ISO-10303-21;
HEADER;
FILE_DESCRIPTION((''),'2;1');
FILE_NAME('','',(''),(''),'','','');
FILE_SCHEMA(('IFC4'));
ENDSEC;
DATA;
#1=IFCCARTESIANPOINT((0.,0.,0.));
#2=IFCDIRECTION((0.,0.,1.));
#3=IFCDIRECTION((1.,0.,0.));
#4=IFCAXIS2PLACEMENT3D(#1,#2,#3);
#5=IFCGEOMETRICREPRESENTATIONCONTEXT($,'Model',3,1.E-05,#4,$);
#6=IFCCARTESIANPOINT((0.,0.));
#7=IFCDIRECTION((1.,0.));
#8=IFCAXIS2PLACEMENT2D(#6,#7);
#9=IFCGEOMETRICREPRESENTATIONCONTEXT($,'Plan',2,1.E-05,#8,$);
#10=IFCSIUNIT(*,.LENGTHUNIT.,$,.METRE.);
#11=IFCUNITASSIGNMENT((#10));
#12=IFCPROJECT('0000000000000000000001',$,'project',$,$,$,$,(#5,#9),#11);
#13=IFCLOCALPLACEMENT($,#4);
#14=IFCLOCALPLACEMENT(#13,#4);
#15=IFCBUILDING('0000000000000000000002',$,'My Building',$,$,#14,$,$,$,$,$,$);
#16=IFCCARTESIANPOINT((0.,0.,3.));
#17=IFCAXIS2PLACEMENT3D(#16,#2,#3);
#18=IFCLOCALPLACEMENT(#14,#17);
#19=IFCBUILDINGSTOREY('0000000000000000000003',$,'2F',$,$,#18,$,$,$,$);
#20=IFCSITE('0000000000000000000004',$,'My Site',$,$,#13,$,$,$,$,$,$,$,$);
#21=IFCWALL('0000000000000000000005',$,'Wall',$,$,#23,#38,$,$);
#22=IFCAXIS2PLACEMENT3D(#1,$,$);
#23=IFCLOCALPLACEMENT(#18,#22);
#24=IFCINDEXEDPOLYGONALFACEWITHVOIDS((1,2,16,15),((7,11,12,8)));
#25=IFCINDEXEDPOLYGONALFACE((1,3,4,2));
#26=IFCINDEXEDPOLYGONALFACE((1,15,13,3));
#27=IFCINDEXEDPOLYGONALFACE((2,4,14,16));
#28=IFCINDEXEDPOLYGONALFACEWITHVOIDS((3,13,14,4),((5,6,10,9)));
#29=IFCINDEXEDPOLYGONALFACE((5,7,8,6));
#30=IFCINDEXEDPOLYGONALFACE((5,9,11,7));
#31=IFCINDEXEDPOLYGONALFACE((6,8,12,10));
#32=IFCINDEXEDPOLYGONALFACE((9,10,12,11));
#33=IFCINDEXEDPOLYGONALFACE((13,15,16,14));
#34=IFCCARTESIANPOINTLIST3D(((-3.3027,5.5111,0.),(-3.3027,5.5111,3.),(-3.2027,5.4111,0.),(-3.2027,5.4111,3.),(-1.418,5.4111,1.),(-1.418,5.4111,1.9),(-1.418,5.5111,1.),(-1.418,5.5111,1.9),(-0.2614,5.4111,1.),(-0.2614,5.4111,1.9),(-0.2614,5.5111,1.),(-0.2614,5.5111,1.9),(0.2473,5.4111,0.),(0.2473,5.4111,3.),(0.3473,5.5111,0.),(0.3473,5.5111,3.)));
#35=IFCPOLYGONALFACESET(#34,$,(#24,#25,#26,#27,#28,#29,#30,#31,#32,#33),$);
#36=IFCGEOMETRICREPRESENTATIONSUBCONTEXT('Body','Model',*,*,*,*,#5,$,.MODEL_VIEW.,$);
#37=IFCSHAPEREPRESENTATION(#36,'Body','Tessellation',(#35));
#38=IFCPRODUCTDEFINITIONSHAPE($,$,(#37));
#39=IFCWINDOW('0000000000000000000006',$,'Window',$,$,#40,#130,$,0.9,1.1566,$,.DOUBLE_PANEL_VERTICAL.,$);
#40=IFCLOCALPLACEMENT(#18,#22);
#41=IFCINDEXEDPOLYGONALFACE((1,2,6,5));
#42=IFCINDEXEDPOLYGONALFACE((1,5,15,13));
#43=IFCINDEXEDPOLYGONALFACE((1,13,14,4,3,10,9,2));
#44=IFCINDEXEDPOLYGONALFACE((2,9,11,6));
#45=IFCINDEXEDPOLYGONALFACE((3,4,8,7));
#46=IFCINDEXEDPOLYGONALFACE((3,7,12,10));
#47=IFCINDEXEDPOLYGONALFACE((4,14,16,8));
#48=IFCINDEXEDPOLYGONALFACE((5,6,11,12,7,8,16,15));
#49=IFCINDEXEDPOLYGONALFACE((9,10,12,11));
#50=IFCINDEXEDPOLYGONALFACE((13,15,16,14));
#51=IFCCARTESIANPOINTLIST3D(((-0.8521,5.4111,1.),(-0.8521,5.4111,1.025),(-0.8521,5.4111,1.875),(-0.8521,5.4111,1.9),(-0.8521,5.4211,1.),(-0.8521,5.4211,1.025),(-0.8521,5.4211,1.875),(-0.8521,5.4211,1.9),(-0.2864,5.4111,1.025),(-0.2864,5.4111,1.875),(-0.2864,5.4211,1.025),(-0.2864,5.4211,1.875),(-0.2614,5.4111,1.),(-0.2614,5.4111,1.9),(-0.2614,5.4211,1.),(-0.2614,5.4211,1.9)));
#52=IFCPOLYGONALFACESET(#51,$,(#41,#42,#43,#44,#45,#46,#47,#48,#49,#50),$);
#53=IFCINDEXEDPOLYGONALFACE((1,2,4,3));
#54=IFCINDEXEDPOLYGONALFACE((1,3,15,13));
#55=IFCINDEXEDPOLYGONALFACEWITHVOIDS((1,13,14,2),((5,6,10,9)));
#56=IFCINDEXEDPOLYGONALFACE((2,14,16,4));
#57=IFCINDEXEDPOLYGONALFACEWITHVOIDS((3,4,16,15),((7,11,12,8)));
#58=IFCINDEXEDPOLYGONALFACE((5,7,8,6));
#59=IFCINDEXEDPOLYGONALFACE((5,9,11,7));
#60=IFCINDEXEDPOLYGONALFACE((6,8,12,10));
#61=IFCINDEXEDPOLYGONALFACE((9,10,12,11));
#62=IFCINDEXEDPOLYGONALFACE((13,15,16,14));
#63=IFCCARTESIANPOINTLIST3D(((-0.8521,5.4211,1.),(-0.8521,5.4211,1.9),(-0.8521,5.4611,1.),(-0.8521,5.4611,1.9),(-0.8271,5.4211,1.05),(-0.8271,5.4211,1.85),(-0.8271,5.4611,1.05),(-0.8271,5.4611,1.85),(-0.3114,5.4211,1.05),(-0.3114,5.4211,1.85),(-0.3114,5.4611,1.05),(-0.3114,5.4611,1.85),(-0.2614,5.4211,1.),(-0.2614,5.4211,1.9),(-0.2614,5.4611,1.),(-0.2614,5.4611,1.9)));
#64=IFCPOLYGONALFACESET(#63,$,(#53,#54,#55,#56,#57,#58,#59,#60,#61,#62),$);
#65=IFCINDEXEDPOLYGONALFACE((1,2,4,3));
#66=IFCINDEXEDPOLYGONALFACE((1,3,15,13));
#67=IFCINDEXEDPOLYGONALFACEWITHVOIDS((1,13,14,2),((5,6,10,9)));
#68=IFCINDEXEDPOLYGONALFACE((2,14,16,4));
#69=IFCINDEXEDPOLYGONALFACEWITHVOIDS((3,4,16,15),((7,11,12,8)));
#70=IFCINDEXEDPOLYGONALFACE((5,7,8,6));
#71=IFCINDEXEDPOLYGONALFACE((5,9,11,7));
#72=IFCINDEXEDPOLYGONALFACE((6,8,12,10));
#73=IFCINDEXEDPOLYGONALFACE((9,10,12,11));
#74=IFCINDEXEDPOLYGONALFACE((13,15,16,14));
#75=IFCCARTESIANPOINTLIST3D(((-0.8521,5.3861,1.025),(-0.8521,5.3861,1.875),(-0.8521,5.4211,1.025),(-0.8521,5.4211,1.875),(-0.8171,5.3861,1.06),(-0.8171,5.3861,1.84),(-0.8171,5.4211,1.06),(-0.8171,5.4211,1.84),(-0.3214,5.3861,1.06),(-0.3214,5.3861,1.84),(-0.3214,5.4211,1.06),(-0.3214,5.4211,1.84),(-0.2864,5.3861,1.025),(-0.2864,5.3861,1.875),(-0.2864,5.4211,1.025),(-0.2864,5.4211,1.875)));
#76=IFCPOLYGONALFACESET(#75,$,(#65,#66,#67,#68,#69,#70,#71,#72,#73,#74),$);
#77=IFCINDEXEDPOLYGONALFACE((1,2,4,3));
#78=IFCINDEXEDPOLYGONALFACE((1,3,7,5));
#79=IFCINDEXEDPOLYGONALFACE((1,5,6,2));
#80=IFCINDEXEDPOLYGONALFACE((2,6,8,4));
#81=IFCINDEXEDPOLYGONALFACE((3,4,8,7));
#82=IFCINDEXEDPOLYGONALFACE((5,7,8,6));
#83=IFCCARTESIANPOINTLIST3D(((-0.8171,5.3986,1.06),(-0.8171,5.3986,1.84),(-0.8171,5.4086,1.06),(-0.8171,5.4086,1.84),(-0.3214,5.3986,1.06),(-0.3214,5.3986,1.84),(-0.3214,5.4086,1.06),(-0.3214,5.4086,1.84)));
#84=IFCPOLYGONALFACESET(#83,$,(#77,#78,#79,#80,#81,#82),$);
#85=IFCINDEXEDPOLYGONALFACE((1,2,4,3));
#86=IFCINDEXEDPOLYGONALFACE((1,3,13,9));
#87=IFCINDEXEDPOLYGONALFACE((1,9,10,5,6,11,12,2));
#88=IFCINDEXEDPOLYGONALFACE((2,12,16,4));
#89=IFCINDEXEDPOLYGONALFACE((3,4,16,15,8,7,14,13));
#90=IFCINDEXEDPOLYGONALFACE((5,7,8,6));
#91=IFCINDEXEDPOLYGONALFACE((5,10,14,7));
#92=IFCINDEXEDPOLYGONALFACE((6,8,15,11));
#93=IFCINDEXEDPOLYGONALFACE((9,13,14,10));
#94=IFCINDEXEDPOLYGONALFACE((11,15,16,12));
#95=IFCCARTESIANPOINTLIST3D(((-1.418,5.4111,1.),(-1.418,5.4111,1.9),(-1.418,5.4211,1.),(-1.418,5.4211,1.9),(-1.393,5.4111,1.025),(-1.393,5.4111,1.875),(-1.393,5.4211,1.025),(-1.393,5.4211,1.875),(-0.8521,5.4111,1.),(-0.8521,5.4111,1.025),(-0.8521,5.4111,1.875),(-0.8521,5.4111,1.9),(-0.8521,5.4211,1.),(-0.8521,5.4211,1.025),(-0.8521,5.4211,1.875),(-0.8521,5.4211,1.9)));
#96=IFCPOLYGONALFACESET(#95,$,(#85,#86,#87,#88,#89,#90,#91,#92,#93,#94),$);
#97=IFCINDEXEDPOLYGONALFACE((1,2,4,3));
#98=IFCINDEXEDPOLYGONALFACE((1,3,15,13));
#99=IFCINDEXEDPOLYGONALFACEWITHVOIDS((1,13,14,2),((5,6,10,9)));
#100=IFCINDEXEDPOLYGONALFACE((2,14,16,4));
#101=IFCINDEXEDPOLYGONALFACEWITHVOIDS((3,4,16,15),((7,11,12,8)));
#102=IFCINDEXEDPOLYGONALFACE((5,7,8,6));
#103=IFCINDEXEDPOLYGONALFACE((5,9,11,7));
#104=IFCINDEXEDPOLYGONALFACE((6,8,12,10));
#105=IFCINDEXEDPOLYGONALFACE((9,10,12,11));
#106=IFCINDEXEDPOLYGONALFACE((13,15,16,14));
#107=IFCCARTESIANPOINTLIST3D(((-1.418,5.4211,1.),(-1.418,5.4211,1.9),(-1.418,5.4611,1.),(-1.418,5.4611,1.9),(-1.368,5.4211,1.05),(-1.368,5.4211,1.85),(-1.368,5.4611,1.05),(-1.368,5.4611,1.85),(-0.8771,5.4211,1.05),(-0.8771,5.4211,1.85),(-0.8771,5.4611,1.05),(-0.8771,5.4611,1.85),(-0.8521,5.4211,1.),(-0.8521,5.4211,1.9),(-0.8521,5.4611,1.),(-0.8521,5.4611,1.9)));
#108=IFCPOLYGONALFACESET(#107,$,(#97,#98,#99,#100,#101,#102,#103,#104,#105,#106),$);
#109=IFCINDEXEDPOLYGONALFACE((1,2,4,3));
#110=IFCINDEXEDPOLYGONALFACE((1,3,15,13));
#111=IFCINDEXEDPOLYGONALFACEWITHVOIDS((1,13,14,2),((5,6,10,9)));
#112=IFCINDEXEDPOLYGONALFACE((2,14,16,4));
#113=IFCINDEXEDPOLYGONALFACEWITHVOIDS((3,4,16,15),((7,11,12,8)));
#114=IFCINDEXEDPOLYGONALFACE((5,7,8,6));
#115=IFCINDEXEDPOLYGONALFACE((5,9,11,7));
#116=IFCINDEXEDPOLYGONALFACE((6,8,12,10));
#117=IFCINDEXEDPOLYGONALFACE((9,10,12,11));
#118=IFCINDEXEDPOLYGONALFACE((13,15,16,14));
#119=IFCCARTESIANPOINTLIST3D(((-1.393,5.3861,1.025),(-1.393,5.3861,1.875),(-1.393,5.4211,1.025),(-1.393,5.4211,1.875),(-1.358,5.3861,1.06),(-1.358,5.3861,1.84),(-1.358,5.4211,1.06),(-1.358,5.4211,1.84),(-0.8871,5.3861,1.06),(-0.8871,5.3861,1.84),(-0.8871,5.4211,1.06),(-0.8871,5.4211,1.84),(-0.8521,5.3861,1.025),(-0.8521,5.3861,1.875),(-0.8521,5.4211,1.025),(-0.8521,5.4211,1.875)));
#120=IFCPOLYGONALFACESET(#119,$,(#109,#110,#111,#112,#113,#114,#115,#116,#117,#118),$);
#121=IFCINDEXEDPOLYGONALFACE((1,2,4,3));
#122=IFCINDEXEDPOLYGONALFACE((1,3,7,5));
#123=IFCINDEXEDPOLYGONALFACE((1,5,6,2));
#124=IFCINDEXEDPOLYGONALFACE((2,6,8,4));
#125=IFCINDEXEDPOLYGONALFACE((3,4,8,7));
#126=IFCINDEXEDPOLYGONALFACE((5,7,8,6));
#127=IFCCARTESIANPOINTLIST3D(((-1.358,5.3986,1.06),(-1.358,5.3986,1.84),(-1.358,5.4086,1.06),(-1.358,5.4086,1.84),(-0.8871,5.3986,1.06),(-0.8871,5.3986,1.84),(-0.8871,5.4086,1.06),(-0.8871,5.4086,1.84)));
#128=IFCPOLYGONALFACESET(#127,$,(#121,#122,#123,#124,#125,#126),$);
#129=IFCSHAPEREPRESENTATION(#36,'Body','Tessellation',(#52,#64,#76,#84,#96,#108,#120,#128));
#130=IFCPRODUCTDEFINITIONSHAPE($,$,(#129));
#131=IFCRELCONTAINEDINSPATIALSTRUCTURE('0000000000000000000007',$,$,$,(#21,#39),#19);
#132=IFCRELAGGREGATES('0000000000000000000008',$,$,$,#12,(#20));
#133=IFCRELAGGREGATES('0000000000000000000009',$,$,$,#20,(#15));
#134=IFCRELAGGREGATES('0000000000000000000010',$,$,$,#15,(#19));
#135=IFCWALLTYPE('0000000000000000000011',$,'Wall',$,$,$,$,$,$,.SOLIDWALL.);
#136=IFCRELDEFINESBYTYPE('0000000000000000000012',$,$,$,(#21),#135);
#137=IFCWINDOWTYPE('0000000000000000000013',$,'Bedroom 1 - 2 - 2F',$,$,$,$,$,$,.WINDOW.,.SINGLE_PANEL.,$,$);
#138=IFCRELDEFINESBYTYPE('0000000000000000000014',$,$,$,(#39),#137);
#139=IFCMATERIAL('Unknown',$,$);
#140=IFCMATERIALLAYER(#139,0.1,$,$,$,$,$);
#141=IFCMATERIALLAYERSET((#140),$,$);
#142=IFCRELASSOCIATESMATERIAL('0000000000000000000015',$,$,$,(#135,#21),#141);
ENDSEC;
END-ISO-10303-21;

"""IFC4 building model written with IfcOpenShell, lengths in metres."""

from ifc_helpers import new_model, entity, si_unit, frame, origin_with_axes, origin_2d_with_axis, place, context, subcontext, project, spatial, line, indexed_curve, outline, extrude, shape, source, transform, mapped, material, layer, layer_set, layer_usage, type_object, type_shapes, element, fill, save


model = new_model("IFC4")

# Units and contexts
model_context = context("Model", 3, precision=1e-05, world=origin_with_axes())
plan_context = context("Plan", 2, precision=1e-05, world=origin_2d_with_axis())
body_context_1 = subcontext(model_context, "Body", "Model", "MODEL_VIEW")
body_context_2 = subcontext(plan_context, "Body", "Plan", "PLAN_VIEW")
ifc_project = project(units=[si_unit("LENGTHUNIT", "METRE")], contexts=[model_context, plan_context])

# Site, building, storey
site_placement = place(None, origin_with_axes())
site = spatial("IfcSite", under=ifc_project, at=site_placement, Name="My Site")
building_placement = place(site_placement, origin_with_axes())
building = spatial("IfcBuilding", under=site, at=building_placement, Name="My Building")
storey_placement = place(building_placement, frame((0.0, 0.0, 3.0), z_axis=(0.0, 0.0, 1.0), x_axis=(1.0, 0.0, 0.0)))
storey = spatial("IfcBuildingStorey", under=building, at=storey_placement, Name="2F")

# Shared definitions
ifc_material = material(Name="Unknown")
ifc_layer = layer(ifc_material, 0.1)
ifc_layer_set = layer_set([ifc_layer])
wall_type = type_object("IfcWallType", Name="Wall", PredefinedType="SOLIDWALL", material=ifc_layer_set)

# Wall, opening, window
ifc_layer_usage_1 = layer_usage(ifc_layer_set, "AXIS2", "POSITIVE", 0.0)
wall_1_placement = place(storey_placement, frame((0.3473, 5.5111, 0.0), z_axis=(0.0, 0.0, 1.0), x_axis=(-1.0, 0.0, 0.0)))
wall_1 = element("IfcWall", 1, at=wall_1_placement, inside=storey, type_object=wall_type, material=ifc_layer_usage_1, Name="Wall", context=body_context_1, shape_type="SweptSolid", body=[
    extrude(outline(indexed_curve([(0.0, 0.0), (0.1, 0.1), (3.55, 0.1), (3.65, 0.0)], segments=[line(1, 2, 3, 4, 1)])), origin_with_axes(), (0.0, 0.0, 1.0), 3.0),
])
shared_shape_1 = source(origin_with_axes(), body_context_1, "Body", "SweptSolid", [
    extrude(outline(indexed_curve([(0.0, 0.0), (1.1566, 0.0), (1.1566, 0.9), (0.0, 0.9)], segments=[line(1, 2, 3, 4, 1)])), frame((0.0, -0.6, 0.0), z_axis=(0.0, -1.0, 0.0), x_axis=(1.0, 0.0, 0.0)), (0.0, 0.0, -1.0), 1.2),
])
opening_1_placement = place(wall_1_placement, frame((0.6086, 0.0, 1.0), z_axis=(0.0, 0.0, 1.0), x_axis=(1.0, 0.0, 0.0)))
opening_1 = element("IfcOpeningElement", 2, at=opening_1_placement, cuts=wall_1, PredefinedType="OPENING", context=body_context_1, shape_type="MappedRepresentation", body=[
    mapped(shared_shape_1, transform((0.0, 0.0, 0.0), x_axis=(1.0, 0.0, 0.0), y_axis=(0.0, 1.0, 0.0), z_axis=(0.0, 0.0, 1.0), scale=1.0)),
])
window_type_1 = type_object("IfcWindowType", Name="Bedroom 1 - 2 - 2F", PartitioningType="SINGLE_PANEL", PredefinedType="WINDOW")
shared_shape_2 = source(origin_with_axes(), body_context_1, "Body", "SweptSolid", [
    extrude(outline(indexed_curve([(0.5908, 0.0), (0.0, 0.0), (0.0, 0.9), (0.5908, 0.9), (0.5908, 0.875), (0.025, 0.875), (0.025, 0.025), (0.5908, 0.025)], segments=[line(1, 2, 3, 4, 5, 6, 7, 8, 1)])), frame((0.0, 0.09, 0.0), z_axis=(0.0, -1.0, 0.0), x_axis=(1.0, 0.0, 0.0)), (0.0, 0.0, -1.0), 0.01),
    extrude(outline(indexed_curve([(0.0, 0.0), (0.5908, 0.0), (0.5908, 0.9), (0.0, 0.9)], segments=[line(1, 2, 3, 4, 1)]), holes=[indexed_curve([(0.05, 0.05), (0.5658, 0.05), (0.5658, 0.85), (0.05, 0.85)], segments=[line(1, 2, 3, 4, 1)])]), frame((0.0, 0.05, 0.0), z_axis=(0.0, -1.0, 0.0), x_axis=(1.0, 0.0, 0.0)), (0.0, 0.0, -1.0), 0.04),
    extrude(outline(indexed_curve([(0.0, 0.0), (0.5658, 0.0), (0.5658, 0.85), (0.0, 0.85)], segments=[line(1, 2, 3, 4, 1)]), holes=[indexed_curve([(0.035, 0.035), (0.5308, 0.035), (0.5308, 0.815), (0.035, 0.815)], segments=[line(1, 2, 3, 4, 1)])]), frame((0.025, 0.09, 0.025), z_axis=(0.0, -1.0, 0.0), x_axis=(1.0, 0.0, 0.0)), (0.0, 0.0, -1.0), 0.035),
    extrude(outline(indexed_curve([(0.035, 0.035), (0.5308, 0.035), (0.5308, 0.815), (0.035, 0.815)], segments=[line(1, 2, 3, 4, 1)])), frame((0.025, 0.1025, 0.025), z_axis=(0.0, -1.0, 0.0), x_axis=(1.0, 0.0, 0.0)), (0.0, 0.0, -1.0), 0.01),
    extrude(outline(indexed_curve([(0.0, 0.9), (0.5659, 0.9), (0.5659, 0.0), (0.0, 0.0), (0.0, 0.025), (0.5409, 0.025), (0.5409, 0.875), (0.0, 0.875)], segments=[line(1, 2, 3, 4, 5, 6, 7, 8, 1)])), frame((0.5908, 0.09, 0.0), z_axis=(0.0, -1.0, 0.0), x_axis=(1.0, 0.0, 0.0)), (0.0, 0.0, -1.0), 0.01),
    extrude(outline(indexed_curve([(0.0, 0.0), (0.5659, 0.0), (0.5659, 0.9), (0.0, 0.9)], segments=[line(1, 2, 3, 4, 1)]), holes=[indexed_curve([(0.025, 0.05), (0.5159, 0.05), (0.5159, 0.85), (0.025, 0.85)], segments=[line(1, 2, 3, 4, 1)])]), frame((0.5908, 0.05, 0.0), z_axis=(0.0, -1.0, 0.0), x_axis=(1.0, 0.0, 0.0)), (0.0, 0.0, -1.0), 0.04),
    extrude(outline(indexed_curve([(0.0, 0.0), (0.5409, 0.0), (0.5409, 0.85), (0.0, 0.85)], segments=[line(1, 2, 3, 4, 1)]), holes=[indexed_curve([(0.035, 0.035), (0.5059, 0.035), (0.5059, 0.815), (0.035, 0.815)], segments=[line(1, 2, 3, 4, 1)])]), frame((0.5908, 0.09, 0.025), z_axis=(0.0, -1.0, 0.0), x_axis=(1.0, 0.0, 0.0)), (0.0, 0.0, -1.0), 0.035),
    extrude(outline(indexed_curve([(0.035, 0.035), (0.5059, 0.035), (0.5059, 0.815), (0.035, 0.815)], segments=[line(1, 2, 3, 4, 1)])), frame((0.5908, 0.1025, 0.025), z_axis=(0.0, -1.0, 0.0), x_axis=(1.0, 0.0, 0.0)), (0.0, 0.0, -1.0), 0.01),
])
shared_shape_3 = source(origin_with_axes(), body_context_2, "Body", "Curve2D", [
    entity("IfcIndexedPolyCurve", entity("IfcCartesianPointList2D", [[0.05, 0.05], [0.5658, 0.05]])),
    entity("IfcIndexedPolyCurve", entity("IfcCartesianPointList2D", [[0.0, 0.1], [0.025, 0.1], [0.025, 0.09], [0.05, 0.09], [0.05, 0.05], [0.0, 0.05]]), [entity("IfcLineIndex", [1, 2, 3, 4, 5, 6, 1])]),
    entity("IfcIndexedPolyCurve", entity("IfcCartesianPointList2D", [[0.5908, 0.1], [0.5908, 0.1], [0.5908, 0.09], [0.5658, 0.09], [0.5658, 0.05], [0.5908, 0.05]])),
    entity("IfcIndexedPolyCurve", entity("IfcCartesianPointList2D", [[0.025, 0.09], [0.06, 0.09], [0.06, 0.125], [0.025, 0.125]]), [entity("IfcLineIndex", [1, 2, 3, 4, 1])]),
    entity("IfcIndexedPolyCurve", entity("IfcCartesianPointList2D", [[0.5908, 0.09], [0.5558, 0.09], [0.5558, 0.125], [0.5908, 0.125]]), [entity("IfcLineIndex", [1, 2, 3, 4, 1])]),
    entity("IfcIndexedPolyCurve", entity("IfcCartesianPointList2D", [[0.06, 0.09], [0.5558, 0.09]])),
    entity("IfcIndexedPolyCurve", entity("IfcCartesianPointList2D", [[0.06, 0.125], [0.5558, 0.125]])),
    entity("IfcIndexedPolyCurve", entity("IfcCartesianPointList2D", [[0.06, 0.1075], [0.5558, 0.1075]])),
    entity("IfcIndexedPolyCurve", entity("IfcCartesianPointList2D", [[0.6158, 0.05], [1.1066, 0.05]])),
    entity("IfcIndexedPolyCurve", entity("IfcCartesianPointList2D", [[0.5908, 0.1], [0.5908, 0.1], [0.5908, 0.09], [0.6158, 0.09], [0.6158, 0.05], [0.5908, 0.05]])),
    entity("IfcIndexedPolyCurve", entity("IfcCartesianPointList2D", [[1.1566, 0.1], [1.1316, 0.1], [1.1316, 0.09], [1.1066, 0.09], [1.1066, 0.05], [1.1566, 0.05]]), [entity("IfcLineIndex", [1, 2, 3, 4, 5, 6, 1])]),
    entity("IfcIndexedPolyCurve", entity("IfcCartesianPointList2D", [[0.5908, 0.09], [0.6258, 0.09], [0.6258, 0.125], [0.5908, 0.125]]), [entity("IfcLineIndex", [1, 2, 3, 4, 1])]),
    entity("IfcIndexedPolyCurve", entity("IfcCartesianPointList2D", [[1.1316, 0.09], [1.0966, 0.09], [1.0966, 0.125], [1.1316, 0.125]]), [entity("IfcLineIndex", [1, 2, 3, 4, 1])]),
    entity("IfcIndexedPolyCurve", entity("IfcCartesianPointList2D", [[0.6258, 0.09], [1.0966, 0.09]])),
    entity("IfcIndexedPolyCurve", entity("IfcCartesianPointList2D", [[0.6258, 0.125], [1.0966, 0.125]])),
    entity("IfcIndexedPolyCurve", entity("IfcCartesianPointList2D", [[0.6258, 0.1075], [1.0966, 0.1075]])),
])
type_shapes(window_type_1, [shared_shape_2, shared_shape_3])
window_1_placement = place(opening_1_placement, frame((0.0, 0.0, 0.0), z_axis=(0.0, 0.0, 1.0), x_axis=(1.0, 0.0, 0.0)))
window_1 = element("IfcWindow", 3, at=window_1_placement, inside=storey, type_object=window_type_1, Name="Window", OverallHeight=0.9, OverallWidth=1.1566, PartitioningType="DOUBLE_PANEL_VERTICAL", shapes=[
    shape(body_context_1, "Body", "MappedRepresentation", [mapped(shared_shape_2, transform((0.0, 0.0, 0.0), x_axis=(1.0, 0.0, 0.0), y_axis=(0.0, 1.0, 0.0), z_axis=(0.0, 0.0, 1.0), scale=1.0))]),
    shape(body_context_2, "Body", "MappedRepresentation", [mapped(shared_shape_3, transform((0.0, 0.0, 0.0), x_axis=(1.0, 0.0, 0.0), y_axis=(0.0, 1.0, 0.0), z_axis=(0.0, 0.0, 1.0), scale=1.0))]),
])
fill(opening_1, window_1)

save(model, "model.ifc")
